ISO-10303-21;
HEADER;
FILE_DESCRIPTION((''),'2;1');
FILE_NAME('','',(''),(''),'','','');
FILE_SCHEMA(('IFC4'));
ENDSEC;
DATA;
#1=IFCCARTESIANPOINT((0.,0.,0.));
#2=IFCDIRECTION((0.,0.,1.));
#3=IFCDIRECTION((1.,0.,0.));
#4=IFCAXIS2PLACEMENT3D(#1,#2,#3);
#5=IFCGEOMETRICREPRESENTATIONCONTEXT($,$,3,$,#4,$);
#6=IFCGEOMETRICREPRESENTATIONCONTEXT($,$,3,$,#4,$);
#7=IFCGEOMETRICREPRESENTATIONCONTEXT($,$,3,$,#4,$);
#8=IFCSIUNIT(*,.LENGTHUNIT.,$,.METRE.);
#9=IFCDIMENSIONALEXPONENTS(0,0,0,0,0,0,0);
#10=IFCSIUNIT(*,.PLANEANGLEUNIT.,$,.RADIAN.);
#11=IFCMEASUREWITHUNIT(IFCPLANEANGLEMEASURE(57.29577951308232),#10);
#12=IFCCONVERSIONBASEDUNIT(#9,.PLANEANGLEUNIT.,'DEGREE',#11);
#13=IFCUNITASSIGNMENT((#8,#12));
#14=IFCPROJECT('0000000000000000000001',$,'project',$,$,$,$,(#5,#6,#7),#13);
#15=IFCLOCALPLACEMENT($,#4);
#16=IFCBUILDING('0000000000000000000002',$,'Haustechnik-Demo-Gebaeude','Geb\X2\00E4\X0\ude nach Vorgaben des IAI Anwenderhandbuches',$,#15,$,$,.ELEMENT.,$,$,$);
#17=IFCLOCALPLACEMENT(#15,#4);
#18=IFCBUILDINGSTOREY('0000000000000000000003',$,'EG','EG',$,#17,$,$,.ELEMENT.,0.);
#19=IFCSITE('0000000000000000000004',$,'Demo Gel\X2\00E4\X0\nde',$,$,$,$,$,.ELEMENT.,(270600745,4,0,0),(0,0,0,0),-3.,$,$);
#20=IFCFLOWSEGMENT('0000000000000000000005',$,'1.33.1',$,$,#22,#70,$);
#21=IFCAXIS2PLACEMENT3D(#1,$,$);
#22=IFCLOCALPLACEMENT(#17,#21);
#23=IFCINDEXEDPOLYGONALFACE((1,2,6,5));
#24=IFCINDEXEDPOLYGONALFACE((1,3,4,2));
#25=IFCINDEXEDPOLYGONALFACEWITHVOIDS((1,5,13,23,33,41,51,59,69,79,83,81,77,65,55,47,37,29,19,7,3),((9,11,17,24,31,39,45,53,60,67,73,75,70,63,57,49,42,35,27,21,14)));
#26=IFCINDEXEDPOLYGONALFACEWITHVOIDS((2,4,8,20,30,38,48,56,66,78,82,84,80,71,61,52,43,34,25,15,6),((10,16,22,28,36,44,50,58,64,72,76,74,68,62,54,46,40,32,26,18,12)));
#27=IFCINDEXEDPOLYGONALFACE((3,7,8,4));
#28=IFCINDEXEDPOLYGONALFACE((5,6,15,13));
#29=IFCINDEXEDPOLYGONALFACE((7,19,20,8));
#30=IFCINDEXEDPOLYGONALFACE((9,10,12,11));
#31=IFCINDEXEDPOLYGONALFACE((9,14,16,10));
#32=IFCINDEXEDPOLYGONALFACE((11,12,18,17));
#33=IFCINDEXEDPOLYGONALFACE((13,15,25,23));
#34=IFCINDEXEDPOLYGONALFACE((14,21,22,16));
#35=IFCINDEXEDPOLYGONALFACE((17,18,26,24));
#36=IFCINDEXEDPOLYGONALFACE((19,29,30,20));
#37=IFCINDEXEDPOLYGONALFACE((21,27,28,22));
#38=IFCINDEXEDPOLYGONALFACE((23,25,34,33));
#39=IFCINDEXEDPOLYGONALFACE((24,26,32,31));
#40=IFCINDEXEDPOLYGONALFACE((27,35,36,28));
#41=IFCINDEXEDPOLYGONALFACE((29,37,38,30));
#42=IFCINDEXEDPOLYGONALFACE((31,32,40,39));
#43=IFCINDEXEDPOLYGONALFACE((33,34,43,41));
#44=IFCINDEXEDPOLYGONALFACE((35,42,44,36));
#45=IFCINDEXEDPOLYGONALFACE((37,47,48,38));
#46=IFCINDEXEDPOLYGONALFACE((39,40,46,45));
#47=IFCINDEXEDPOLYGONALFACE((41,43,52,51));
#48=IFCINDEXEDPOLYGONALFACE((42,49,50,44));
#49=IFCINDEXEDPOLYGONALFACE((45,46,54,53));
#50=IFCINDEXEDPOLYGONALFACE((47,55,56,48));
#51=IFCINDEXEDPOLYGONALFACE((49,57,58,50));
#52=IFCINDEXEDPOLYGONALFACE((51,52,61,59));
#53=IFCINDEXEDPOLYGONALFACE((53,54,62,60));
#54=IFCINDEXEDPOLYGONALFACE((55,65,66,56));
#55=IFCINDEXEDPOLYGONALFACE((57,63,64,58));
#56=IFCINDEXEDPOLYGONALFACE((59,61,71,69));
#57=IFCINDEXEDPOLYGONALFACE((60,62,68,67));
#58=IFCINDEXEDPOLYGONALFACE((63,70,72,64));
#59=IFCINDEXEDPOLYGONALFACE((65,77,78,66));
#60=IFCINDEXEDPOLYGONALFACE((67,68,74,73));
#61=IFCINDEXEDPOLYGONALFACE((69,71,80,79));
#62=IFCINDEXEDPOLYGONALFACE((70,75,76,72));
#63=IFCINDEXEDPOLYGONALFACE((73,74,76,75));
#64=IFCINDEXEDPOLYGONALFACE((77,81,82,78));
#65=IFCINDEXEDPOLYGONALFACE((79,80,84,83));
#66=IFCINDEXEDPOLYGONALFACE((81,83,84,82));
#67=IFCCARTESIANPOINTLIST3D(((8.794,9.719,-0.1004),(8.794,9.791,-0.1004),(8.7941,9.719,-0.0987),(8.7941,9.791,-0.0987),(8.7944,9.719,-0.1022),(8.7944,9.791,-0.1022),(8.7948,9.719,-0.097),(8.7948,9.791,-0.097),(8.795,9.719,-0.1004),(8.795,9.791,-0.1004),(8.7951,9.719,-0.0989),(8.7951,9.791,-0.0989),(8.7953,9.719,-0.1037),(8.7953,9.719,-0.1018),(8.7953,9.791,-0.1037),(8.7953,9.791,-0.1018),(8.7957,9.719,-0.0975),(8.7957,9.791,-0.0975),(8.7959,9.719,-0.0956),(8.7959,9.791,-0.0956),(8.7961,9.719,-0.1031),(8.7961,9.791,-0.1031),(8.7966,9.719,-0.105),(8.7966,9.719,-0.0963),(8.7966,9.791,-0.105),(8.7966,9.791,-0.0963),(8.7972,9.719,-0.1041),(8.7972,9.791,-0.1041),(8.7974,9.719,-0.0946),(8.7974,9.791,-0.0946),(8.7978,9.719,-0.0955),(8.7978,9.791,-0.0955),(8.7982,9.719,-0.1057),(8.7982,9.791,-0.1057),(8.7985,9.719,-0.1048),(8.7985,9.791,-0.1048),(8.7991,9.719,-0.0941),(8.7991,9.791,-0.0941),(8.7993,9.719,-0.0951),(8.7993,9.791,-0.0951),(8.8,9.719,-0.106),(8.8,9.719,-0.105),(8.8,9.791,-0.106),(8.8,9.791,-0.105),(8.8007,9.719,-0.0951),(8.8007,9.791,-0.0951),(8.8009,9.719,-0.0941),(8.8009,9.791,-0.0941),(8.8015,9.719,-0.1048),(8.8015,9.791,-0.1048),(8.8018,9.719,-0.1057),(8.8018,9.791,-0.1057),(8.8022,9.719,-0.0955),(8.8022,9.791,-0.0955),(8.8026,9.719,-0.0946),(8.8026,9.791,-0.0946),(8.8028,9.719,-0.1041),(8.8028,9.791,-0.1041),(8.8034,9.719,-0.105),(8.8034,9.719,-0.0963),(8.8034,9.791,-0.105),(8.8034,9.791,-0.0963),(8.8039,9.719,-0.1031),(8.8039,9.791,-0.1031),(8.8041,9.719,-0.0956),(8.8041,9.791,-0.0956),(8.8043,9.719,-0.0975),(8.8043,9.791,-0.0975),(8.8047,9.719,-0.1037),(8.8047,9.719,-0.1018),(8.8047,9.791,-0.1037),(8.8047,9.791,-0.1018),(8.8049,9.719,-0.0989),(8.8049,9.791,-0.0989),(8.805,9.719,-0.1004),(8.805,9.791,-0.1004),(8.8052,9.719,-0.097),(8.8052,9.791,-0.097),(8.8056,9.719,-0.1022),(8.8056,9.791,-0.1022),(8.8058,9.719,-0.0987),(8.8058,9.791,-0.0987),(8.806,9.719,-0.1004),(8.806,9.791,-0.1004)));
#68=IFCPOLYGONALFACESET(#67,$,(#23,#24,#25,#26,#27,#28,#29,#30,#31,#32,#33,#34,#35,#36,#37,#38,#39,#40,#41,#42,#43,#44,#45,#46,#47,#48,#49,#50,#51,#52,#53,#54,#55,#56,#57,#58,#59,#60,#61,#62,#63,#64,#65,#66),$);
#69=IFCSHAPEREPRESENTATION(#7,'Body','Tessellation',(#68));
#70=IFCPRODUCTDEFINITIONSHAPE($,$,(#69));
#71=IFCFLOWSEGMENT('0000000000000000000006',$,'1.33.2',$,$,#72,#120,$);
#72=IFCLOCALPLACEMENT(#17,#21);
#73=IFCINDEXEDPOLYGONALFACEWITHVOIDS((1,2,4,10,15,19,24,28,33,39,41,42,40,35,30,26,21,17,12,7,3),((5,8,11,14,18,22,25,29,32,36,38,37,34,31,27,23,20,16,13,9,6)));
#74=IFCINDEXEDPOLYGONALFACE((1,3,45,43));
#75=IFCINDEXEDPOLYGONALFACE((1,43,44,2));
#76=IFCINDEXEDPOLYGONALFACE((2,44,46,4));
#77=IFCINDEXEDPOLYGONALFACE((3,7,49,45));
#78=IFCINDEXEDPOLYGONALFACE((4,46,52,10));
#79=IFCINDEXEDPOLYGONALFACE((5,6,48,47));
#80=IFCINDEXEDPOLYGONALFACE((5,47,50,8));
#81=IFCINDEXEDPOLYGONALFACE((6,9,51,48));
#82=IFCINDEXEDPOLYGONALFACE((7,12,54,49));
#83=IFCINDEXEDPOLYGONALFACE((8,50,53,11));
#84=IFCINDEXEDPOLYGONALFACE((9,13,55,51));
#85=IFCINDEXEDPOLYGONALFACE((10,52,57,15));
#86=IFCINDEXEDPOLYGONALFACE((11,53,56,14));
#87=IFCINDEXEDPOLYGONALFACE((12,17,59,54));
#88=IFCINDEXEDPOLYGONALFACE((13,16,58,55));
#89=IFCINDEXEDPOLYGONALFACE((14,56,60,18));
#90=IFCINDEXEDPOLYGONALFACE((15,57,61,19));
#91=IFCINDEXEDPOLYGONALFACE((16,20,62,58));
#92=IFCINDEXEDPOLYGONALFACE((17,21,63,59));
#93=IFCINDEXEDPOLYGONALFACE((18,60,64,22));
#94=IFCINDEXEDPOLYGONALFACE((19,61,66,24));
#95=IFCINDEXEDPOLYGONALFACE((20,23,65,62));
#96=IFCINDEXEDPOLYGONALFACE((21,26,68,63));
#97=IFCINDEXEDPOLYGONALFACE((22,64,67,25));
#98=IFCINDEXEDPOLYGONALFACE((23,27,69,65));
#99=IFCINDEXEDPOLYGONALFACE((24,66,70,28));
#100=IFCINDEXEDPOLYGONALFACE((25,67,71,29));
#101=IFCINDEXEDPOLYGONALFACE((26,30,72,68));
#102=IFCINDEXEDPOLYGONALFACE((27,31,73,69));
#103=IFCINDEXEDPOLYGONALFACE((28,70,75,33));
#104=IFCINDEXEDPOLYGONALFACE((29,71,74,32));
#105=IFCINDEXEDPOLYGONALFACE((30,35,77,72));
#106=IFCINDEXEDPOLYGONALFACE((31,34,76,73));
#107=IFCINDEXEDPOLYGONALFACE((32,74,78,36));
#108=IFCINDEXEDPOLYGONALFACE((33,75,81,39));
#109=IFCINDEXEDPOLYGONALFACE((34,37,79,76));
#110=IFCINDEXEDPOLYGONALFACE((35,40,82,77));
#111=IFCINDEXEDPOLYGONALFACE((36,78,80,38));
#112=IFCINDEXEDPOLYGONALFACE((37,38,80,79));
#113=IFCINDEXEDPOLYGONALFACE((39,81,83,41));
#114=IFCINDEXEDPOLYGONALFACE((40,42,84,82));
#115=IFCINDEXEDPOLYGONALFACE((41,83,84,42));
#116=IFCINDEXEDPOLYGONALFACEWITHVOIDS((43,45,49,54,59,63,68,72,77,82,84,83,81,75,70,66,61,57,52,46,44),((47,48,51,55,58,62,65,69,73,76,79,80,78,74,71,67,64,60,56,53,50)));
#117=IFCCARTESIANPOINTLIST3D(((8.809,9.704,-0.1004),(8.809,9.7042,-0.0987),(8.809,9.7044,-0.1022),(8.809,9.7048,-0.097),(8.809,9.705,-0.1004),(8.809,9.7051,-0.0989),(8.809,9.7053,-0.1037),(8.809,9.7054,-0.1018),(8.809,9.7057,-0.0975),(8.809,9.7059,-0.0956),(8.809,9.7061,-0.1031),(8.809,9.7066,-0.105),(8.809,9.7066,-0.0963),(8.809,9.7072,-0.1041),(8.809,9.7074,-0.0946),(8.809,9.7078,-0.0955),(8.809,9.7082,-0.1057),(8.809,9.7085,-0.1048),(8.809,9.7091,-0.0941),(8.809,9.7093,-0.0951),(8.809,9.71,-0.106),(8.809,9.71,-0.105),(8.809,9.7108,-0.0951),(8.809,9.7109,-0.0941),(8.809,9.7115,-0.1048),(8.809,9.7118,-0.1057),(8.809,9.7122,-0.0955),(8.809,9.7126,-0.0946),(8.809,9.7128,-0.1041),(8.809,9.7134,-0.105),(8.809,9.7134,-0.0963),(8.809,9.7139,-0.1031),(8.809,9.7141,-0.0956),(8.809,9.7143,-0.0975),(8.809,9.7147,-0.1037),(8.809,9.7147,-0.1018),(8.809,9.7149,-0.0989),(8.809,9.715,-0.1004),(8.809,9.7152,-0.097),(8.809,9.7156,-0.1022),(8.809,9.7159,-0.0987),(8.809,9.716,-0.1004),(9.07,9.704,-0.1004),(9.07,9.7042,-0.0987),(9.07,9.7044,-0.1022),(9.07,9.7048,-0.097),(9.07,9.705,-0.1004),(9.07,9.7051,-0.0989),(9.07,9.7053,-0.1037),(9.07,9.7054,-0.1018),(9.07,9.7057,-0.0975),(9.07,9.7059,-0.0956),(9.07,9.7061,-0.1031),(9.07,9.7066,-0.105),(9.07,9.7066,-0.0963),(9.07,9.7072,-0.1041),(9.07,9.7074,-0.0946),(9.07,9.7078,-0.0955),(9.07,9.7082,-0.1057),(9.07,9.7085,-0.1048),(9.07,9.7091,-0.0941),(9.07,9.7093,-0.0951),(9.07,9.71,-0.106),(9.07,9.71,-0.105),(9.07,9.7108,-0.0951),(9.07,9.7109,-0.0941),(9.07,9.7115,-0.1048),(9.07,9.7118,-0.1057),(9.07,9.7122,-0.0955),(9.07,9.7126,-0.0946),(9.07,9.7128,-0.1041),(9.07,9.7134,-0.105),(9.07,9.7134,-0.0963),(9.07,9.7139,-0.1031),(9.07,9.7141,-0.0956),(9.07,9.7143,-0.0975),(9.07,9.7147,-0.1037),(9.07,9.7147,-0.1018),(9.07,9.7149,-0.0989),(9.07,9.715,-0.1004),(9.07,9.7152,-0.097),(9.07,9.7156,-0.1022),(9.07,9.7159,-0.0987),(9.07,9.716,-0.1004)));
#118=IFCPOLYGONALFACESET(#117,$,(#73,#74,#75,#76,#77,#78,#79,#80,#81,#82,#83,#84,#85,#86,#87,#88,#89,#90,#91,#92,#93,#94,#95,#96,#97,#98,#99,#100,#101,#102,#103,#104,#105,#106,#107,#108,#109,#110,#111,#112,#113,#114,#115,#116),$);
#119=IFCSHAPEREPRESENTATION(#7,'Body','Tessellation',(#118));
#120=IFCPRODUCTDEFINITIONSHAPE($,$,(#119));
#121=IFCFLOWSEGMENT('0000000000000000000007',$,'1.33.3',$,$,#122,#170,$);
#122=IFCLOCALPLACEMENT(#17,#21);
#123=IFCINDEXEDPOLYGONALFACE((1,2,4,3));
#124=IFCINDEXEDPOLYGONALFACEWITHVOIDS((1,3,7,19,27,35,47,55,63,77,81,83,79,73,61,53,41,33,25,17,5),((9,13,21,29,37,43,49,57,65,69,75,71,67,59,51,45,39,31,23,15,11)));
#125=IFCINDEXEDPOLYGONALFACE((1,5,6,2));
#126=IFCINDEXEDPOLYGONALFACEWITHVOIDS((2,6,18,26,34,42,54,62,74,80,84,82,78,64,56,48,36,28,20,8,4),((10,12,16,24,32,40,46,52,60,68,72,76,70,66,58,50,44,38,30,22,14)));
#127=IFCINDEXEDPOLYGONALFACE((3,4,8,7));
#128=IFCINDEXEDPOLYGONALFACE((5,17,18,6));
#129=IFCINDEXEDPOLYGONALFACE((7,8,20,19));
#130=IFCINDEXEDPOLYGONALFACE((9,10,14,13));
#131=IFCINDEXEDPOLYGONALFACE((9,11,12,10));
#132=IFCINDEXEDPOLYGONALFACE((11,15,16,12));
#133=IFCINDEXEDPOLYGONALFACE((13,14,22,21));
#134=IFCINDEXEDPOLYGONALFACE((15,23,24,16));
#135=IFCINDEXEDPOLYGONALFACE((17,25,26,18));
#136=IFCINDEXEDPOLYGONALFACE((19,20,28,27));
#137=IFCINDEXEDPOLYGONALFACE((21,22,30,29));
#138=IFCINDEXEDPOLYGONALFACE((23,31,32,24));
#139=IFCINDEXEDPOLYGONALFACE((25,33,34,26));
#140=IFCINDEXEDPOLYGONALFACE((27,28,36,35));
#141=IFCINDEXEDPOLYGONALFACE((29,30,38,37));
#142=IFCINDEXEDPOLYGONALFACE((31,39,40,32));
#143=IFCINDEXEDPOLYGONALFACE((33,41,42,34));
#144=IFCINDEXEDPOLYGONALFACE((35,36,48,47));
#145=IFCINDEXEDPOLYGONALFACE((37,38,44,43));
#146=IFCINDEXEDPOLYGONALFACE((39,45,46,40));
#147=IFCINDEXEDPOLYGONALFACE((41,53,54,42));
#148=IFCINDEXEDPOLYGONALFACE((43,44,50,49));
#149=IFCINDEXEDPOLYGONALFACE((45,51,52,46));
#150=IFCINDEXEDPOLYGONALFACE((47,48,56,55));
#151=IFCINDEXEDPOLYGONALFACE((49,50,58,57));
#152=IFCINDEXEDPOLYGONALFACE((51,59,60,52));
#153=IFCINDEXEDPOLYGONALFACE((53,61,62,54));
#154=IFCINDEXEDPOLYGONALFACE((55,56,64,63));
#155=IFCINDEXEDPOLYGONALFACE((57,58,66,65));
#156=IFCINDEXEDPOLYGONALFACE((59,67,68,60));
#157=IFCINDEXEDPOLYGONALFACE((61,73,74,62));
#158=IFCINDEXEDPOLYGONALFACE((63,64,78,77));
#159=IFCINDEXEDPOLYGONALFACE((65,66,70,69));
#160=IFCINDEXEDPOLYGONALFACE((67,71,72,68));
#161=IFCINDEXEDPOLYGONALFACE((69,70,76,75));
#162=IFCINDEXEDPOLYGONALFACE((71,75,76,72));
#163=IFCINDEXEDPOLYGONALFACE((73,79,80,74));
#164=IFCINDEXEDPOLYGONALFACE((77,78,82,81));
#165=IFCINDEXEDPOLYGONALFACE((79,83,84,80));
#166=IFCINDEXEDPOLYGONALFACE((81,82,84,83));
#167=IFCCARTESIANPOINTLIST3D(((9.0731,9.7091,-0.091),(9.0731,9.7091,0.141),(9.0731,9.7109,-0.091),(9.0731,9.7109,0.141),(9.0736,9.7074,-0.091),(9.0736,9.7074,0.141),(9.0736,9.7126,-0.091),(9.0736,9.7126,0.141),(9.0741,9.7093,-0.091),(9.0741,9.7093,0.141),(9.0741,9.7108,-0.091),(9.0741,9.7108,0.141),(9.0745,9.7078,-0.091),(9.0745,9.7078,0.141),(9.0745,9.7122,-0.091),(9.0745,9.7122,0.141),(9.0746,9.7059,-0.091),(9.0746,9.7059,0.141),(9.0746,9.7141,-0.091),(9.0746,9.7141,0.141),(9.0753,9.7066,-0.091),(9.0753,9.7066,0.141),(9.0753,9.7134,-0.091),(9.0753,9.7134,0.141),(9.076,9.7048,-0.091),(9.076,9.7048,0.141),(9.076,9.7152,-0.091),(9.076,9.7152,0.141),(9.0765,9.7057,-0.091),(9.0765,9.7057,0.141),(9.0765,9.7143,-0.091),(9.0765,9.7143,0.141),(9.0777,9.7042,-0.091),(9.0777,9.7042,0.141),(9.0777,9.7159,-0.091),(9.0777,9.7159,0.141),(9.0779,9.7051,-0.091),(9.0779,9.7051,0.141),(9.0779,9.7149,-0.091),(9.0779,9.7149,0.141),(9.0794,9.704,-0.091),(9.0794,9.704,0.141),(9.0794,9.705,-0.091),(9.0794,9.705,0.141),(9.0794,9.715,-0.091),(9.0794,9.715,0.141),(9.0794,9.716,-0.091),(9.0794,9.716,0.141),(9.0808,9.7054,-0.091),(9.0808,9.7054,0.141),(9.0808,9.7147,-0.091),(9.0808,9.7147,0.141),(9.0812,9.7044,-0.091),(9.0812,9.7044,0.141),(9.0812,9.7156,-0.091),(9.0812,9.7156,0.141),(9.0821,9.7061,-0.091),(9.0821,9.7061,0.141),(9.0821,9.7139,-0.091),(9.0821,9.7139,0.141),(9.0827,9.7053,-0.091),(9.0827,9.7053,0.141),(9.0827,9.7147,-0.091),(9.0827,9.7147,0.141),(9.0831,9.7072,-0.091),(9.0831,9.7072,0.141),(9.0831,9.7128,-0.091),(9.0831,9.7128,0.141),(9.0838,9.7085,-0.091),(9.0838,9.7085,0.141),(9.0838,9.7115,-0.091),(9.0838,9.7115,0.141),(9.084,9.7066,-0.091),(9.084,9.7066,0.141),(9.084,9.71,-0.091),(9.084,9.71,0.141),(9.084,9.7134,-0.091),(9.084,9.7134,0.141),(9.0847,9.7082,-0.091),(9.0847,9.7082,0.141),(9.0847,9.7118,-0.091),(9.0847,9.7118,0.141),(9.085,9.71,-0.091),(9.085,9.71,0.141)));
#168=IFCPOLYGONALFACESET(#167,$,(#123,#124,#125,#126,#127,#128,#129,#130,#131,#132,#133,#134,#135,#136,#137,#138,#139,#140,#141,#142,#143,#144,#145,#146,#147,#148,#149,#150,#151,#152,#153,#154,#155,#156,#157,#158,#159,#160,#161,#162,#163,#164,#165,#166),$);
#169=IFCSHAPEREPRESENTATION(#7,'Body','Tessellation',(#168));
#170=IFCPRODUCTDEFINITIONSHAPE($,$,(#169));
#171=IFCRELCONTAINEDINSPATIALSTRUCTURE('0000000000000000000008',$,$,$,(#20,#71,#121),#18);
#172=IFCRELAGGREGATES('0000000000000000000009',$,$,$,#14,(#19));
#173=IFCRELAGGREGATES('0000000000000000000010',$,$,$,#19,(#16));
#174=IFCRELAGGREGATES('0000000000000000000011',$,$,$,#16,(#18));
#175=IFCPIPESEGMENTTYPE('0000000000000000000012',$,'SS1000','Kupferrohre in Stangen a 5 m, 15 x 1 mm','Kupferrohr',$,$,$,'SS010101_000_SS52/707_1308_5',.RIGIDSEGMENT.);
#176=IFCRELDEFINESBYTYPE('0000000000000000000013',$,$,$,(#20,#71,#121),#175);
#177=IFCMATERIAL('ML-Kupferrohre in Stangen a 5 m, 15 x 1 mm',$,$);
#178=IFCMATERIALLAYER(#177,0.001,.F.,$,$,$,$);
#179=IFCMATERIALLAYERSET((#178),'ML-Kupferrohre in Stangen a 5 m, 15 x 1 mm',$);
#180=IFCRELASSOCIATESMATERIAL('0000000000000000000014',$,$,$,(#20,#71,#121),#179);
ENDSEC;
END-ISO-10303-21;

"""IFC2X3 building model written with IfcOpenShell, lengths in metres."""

from ifc_helpers import new_model, entity, si_unit, converted_unit, frame, origin_with_axes, origin_2d_with_axis, place, context, project, spatial, hollow_circle, extrude, material, layer, layer_set, layer_usage, type_object, element, save


model = new_model("IFC2X3")

# Units and contexts
context_of_model_1 = context(None, 3, world=origin_with_axes())
context_of_model_2 = context(None, 3, world=origin_with_axes())
context_of_model_3 = context(None, 3, world=origin_with_axes())
ifc_project = project(units=[si_unit("LENGTHUNIT", "METRE"), converted_unit("PLANEANGLEUNIT", "DEGREE", entity("IfcPlaneAngleMeasure", 57.29577951308232), si_unit("PLANEANGLEUNIT", "RADIAN"), dimensions=[0, 0, 0, 0, 0, 0, 0])], contexts=[context_of_model_1, context_of_model_2, context_of_model_3])

# Site, building, storey
site = spatial("IfcSite", under=ifc_project, Name="Demo Gelände", CompositionType="ELEMENT", RefLatitude=(270600745, 4, 0, 0), RefLongitude=(0, 0, 0, 0), RefElevation=-3.0)
building_placement = place(None, origin_with_axes())
building = spatial("IfcBuilding", under=site, at=building_placement, Name="Haustechnik-Demo-Gebaeude", Description="Gebäude nach Vorgaben des IAI Anwenderhandbuches", CompositionType="ELEMENT")
storey_placement = place(building_placement, origin_with_axes())
storey = spatial("IfcBuildingStorey", under=building, at=storey_placement, Name="EG", Description="EG", CompositionType="ELEMENT", Elevation=0.0)

# Flow segments
ifc_material_1 = material(Name="ML-Kupferrohre in Stangen a 5 m, 15 x 1 mm")
ifc_layer_1 = layer(ifc_material_1, 0.001, ventilated=False)
ifc_layer_set_1 = layer_set([ifc_layer_1], Name="ML-Kupferrohre in Stangen a 5 m, 15 x 1 mm")
ifc_layer_usage_1 = layer_usage(ifc_layer_set_1, "AXIS2", "POSITIVE", 0.0)
pipe_segment_type_1 = type_object("IfcPipeSegmentType", Name="SS1000", Description="Kupferrohre in Stangen a 5 m, 15 x 1 mm", ApplicableOccurrence="Kupferrohr", ElementType="SS010101_000_SS52/707_1308_5", PredefinedType="RIGIDSEGMENT")
flow_segment_1_placement = place(storey_placement, frame((8.8, 9.791, -0.1), z_axis=(0.0, -1.0, 0.0), x_axis=(0.0, 0.0, -1.0)))
element("IfcFlowSegment", 1, at=flow_segment_1_placement, inside=storey, type_object=pipe_segment_type_1, material=ifc_layer_usage_1, Name="1.33.1", context=context_of_model_3, shape_type="SweptSolid", body=[
    extrude(hollow_circle(Radius=0.006, WallThickness=0.001, at=origin_2d_with_axis()), origin_with_axes(), (0.0, 0.0, 1.0), 0.072),
])
flow_segment_2_placement = place(storey_placement, frame((8.809, 9.71, -0.1), z_axis=(1.0, 0.0, 0.0), x_axis=(0.0, 0.0, -1.0)))
element("IfcFlowSegment", 2, at=flow_segment_2_placement, inside=storey, type_object=pipe_segment_type_1, material=ifc_layer_usage_1, Name="1.33.2", context=context_of_model_3, shape_type="SweptSolid", body=[
    extrude(hollow_circle(Radius=0.006, WallThickness=0.001, at=origin_2d_with_axis()), origin_with_axes(), (0.0, 0.0, 1.0), 0.261),
])
flow_segment_3_placement = place(storey_placement, frame((9.079, 9.71, -0.091), z_axis=(0.0, 0.0, 1.0), x_axis=(1.0, 0.0, 0.0)))
element("IfcFlowSegment", 3, at=flow_segment_3_placement, inside=storey, type_object=pipe_segment_type_1, material=ifc_layer_usage_1, Name="1.33.3", context=context_of_model_3, shape_type="SweptSolid", body=[
    extrude(hollow_circle(Radius=0.006, WallThickness=0.001, at=origin_2d_with_axis()), origin_with_axes(), (0.0, 0.0, 1.0), 0.232),
])

save(model, "model.ifc")
